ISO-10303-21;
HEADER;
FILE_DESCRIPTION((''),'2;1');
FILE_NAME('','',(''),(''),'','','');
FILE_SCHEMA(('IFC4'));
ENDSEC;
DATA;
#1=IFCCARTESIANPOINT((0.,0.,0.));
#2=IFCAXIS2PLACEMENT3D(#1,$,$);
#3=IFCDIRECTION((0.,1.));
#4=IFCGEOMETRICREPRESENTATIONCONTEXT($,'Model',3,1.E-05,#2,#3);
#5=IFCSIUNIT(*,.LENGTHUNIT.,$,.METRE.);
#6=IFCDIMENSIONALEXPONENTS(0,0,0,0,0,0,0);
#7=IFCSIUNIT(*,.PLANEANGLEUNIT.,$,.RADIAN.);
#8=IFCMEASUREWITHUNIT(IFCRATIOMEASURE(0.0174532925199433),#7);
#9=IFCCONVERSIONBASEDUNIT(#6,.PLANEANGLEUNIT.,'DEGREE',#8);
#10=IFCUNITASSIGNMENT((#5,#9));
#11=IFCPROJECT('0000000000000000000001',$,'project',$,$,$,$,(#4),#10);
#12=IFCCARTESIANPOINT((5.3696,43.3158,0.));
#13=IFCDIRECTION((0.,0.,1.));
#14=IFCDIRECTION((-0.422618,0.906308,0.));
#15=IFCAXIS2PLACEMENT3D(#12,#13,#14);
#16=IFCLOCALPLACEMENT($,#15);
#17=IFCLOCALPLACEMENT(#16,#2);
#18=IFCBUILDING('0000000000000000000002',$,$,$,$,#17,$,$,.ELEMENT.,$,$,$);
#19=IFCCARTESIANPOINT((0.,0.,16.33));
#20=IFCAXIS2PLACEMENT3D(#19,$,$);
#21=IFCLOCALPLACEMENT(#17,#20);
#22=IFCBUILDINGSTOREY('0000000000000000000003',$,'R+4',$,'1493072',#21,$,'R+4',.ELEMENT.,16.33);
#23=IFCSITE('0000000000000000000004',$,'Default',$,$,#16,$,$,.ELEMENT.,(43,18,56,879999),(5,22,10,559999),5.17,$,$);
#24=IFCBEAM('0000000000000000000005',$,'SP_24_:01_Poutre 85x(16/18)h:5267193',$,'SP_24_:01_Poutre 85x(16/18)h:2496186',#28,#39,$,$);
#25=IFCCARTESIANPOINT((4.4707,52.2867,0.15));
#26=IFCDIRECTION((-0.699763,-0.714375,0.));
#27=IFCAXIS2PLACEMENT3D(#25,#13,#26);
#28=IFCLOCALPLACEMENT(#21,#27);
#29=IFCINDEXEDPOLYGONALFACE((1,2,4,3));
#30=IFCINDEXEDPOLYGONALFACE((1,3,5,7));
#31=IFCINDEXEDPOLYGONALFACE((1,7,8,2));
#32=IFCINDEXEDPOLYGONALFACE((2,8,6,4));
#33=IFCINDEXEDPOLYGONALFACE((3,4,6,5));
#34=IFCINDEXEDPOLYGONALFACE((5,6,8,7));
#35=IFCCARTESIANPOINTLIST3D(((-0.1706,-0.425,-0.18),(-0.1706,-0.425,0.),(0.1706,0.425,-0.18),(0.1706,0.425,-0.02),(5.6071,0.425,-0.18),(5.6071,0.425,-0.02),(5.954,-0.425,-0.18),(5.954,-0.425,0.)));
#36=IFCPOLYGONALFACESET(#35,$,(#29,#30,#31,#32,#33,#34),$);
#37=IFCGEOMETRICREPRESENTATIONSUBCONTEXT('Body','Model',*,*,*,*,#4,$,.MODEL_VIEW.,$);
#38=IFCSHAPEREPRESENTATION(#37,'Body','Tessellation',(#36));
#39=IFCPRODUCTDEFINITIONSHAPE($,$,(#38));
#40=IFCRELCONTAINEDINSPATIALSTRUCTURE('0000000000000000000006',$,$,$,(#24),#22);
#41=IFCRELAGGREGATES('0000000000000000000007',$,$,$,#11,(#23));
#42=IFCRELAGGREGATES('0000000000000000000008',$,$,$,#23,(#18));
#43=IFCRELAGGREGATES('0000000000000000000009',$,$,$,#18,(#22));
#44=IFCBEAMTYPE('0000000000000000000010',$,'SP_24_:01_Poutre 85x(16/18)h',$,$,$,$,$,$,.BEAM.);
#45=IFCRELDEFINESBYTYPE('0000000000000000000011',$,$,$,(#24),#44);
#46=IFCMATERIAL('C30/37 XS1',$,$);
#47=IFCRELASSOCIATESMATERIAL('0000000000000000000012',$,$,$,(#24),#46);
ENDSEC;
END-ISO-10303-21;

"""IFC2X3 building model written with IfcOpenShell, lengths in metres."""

from ifc_helpers import new_model, entity, si_unit, converted_unit, direction, frame, origin, place, context, subcontext, project, spatial, polyline, outline, extrude, clip, halfspace, material, type_object, element, save


model = new_model("IFC2X3")

# Units and contexts
model_context = context("Model", 3, precision=1e-05, world=origin(), true_north=direction((0.0, 1.0)))
body_context = subcontext(model_context, "Body", "Model", "MODEL_VIEW")
ifc_project = project(units=[si_unit("LENGTHUNIT", "METRE"), converted_unit("PLANEANGLEUNIT", "DEGREE", entity("IfcRatioMeasure", 0.0174532925199433), si_unit("PLANEANGLEUNIT", "RADIAN"), dimensions=[0, 0, 0, 0, 0, 0, 0])], contexts=[model_context])

# Site, building, storey
site_placement = place(None, frame((5.3696, 43.3158, 0.0), z_axis=(0.0, 0.0, 1.0), x_axis=(-0.422618, 0.906308, 0.0)))
site = spatial("IfcSite", under=ifc_project, at=site_placement, Name="Default", CompositionType="ELEMENT", RefLatitude=(43, 18, 56, 879999), RefLongitude=(5, 22, 10, 559999), RefElevation=5.17)
building_placement = place(site_placement, origin())
building = spatial("IfcBuilding", under=site, at=building_placement, CompositionType="ELEMENT")
storey_placement = place(building_placement, frame((0.0, 0.0, 16.33)))
storey = spatial("IfcBuildingStorey", under=building, at=storey_placement, Name="R+4", ObjectType="1493072", LongName="R+4", CompositionType="ELEMENT", Elevation=16.33)

# Beam
ifc_material_1 = material(Name="C30/37 XS1")
beam_type_1 = type_object("IfcBeamType", Name="SP_24_:01_Poutre 85x(16/18)h", PredefinedType="BEAM")
beam_1_placement = place(storey_placement, frame((4.4707, 52.2867, 0.15), z_axis=(0.0, 0.0, 1.0), x_axis=(-0.699763, -0.714375, 0.0)))
element("IfcBeam", 1, at=beam_1_placement, inside=storey, type_object=beam_type_1, material=ifc_material_1, Name="SP_24_:01_Poutre 85x(16/18)h:5267193", ObjectType="SP_24_:01_Poutre 85x(16/18)h:2496186", context=body_context, shape_type="Clipping", body=[
    clip(clip(extrude(outline(polyline([(-0.095, -0.425), (0.085, -0.425), (0.085, 0.425), (-0.075, 0.425), (-0.095, -0.425)])), frame((-0.1706, 0.0, -0.095), z_axis=(1.0, 0.0, 0.0), x_axis=(0.0, 0.0, -1.0)), (0.0, 0.0, 1.0), 6.1247), halfspace(frame((5.6071, 0.425, 0.0), z_axis=(0.925844, 0.377906, 0.0), x_axis=(-0.377906, 0.925844, 0.0)), False)), halfspace(frame((0.1706, 0.425, 0.0), z_axis=(-0.928012, 0.372551, 0.0), x_axis=(0.372551, 0.928012, 0.0)), False)),
])

save(model, "model.ifc")
